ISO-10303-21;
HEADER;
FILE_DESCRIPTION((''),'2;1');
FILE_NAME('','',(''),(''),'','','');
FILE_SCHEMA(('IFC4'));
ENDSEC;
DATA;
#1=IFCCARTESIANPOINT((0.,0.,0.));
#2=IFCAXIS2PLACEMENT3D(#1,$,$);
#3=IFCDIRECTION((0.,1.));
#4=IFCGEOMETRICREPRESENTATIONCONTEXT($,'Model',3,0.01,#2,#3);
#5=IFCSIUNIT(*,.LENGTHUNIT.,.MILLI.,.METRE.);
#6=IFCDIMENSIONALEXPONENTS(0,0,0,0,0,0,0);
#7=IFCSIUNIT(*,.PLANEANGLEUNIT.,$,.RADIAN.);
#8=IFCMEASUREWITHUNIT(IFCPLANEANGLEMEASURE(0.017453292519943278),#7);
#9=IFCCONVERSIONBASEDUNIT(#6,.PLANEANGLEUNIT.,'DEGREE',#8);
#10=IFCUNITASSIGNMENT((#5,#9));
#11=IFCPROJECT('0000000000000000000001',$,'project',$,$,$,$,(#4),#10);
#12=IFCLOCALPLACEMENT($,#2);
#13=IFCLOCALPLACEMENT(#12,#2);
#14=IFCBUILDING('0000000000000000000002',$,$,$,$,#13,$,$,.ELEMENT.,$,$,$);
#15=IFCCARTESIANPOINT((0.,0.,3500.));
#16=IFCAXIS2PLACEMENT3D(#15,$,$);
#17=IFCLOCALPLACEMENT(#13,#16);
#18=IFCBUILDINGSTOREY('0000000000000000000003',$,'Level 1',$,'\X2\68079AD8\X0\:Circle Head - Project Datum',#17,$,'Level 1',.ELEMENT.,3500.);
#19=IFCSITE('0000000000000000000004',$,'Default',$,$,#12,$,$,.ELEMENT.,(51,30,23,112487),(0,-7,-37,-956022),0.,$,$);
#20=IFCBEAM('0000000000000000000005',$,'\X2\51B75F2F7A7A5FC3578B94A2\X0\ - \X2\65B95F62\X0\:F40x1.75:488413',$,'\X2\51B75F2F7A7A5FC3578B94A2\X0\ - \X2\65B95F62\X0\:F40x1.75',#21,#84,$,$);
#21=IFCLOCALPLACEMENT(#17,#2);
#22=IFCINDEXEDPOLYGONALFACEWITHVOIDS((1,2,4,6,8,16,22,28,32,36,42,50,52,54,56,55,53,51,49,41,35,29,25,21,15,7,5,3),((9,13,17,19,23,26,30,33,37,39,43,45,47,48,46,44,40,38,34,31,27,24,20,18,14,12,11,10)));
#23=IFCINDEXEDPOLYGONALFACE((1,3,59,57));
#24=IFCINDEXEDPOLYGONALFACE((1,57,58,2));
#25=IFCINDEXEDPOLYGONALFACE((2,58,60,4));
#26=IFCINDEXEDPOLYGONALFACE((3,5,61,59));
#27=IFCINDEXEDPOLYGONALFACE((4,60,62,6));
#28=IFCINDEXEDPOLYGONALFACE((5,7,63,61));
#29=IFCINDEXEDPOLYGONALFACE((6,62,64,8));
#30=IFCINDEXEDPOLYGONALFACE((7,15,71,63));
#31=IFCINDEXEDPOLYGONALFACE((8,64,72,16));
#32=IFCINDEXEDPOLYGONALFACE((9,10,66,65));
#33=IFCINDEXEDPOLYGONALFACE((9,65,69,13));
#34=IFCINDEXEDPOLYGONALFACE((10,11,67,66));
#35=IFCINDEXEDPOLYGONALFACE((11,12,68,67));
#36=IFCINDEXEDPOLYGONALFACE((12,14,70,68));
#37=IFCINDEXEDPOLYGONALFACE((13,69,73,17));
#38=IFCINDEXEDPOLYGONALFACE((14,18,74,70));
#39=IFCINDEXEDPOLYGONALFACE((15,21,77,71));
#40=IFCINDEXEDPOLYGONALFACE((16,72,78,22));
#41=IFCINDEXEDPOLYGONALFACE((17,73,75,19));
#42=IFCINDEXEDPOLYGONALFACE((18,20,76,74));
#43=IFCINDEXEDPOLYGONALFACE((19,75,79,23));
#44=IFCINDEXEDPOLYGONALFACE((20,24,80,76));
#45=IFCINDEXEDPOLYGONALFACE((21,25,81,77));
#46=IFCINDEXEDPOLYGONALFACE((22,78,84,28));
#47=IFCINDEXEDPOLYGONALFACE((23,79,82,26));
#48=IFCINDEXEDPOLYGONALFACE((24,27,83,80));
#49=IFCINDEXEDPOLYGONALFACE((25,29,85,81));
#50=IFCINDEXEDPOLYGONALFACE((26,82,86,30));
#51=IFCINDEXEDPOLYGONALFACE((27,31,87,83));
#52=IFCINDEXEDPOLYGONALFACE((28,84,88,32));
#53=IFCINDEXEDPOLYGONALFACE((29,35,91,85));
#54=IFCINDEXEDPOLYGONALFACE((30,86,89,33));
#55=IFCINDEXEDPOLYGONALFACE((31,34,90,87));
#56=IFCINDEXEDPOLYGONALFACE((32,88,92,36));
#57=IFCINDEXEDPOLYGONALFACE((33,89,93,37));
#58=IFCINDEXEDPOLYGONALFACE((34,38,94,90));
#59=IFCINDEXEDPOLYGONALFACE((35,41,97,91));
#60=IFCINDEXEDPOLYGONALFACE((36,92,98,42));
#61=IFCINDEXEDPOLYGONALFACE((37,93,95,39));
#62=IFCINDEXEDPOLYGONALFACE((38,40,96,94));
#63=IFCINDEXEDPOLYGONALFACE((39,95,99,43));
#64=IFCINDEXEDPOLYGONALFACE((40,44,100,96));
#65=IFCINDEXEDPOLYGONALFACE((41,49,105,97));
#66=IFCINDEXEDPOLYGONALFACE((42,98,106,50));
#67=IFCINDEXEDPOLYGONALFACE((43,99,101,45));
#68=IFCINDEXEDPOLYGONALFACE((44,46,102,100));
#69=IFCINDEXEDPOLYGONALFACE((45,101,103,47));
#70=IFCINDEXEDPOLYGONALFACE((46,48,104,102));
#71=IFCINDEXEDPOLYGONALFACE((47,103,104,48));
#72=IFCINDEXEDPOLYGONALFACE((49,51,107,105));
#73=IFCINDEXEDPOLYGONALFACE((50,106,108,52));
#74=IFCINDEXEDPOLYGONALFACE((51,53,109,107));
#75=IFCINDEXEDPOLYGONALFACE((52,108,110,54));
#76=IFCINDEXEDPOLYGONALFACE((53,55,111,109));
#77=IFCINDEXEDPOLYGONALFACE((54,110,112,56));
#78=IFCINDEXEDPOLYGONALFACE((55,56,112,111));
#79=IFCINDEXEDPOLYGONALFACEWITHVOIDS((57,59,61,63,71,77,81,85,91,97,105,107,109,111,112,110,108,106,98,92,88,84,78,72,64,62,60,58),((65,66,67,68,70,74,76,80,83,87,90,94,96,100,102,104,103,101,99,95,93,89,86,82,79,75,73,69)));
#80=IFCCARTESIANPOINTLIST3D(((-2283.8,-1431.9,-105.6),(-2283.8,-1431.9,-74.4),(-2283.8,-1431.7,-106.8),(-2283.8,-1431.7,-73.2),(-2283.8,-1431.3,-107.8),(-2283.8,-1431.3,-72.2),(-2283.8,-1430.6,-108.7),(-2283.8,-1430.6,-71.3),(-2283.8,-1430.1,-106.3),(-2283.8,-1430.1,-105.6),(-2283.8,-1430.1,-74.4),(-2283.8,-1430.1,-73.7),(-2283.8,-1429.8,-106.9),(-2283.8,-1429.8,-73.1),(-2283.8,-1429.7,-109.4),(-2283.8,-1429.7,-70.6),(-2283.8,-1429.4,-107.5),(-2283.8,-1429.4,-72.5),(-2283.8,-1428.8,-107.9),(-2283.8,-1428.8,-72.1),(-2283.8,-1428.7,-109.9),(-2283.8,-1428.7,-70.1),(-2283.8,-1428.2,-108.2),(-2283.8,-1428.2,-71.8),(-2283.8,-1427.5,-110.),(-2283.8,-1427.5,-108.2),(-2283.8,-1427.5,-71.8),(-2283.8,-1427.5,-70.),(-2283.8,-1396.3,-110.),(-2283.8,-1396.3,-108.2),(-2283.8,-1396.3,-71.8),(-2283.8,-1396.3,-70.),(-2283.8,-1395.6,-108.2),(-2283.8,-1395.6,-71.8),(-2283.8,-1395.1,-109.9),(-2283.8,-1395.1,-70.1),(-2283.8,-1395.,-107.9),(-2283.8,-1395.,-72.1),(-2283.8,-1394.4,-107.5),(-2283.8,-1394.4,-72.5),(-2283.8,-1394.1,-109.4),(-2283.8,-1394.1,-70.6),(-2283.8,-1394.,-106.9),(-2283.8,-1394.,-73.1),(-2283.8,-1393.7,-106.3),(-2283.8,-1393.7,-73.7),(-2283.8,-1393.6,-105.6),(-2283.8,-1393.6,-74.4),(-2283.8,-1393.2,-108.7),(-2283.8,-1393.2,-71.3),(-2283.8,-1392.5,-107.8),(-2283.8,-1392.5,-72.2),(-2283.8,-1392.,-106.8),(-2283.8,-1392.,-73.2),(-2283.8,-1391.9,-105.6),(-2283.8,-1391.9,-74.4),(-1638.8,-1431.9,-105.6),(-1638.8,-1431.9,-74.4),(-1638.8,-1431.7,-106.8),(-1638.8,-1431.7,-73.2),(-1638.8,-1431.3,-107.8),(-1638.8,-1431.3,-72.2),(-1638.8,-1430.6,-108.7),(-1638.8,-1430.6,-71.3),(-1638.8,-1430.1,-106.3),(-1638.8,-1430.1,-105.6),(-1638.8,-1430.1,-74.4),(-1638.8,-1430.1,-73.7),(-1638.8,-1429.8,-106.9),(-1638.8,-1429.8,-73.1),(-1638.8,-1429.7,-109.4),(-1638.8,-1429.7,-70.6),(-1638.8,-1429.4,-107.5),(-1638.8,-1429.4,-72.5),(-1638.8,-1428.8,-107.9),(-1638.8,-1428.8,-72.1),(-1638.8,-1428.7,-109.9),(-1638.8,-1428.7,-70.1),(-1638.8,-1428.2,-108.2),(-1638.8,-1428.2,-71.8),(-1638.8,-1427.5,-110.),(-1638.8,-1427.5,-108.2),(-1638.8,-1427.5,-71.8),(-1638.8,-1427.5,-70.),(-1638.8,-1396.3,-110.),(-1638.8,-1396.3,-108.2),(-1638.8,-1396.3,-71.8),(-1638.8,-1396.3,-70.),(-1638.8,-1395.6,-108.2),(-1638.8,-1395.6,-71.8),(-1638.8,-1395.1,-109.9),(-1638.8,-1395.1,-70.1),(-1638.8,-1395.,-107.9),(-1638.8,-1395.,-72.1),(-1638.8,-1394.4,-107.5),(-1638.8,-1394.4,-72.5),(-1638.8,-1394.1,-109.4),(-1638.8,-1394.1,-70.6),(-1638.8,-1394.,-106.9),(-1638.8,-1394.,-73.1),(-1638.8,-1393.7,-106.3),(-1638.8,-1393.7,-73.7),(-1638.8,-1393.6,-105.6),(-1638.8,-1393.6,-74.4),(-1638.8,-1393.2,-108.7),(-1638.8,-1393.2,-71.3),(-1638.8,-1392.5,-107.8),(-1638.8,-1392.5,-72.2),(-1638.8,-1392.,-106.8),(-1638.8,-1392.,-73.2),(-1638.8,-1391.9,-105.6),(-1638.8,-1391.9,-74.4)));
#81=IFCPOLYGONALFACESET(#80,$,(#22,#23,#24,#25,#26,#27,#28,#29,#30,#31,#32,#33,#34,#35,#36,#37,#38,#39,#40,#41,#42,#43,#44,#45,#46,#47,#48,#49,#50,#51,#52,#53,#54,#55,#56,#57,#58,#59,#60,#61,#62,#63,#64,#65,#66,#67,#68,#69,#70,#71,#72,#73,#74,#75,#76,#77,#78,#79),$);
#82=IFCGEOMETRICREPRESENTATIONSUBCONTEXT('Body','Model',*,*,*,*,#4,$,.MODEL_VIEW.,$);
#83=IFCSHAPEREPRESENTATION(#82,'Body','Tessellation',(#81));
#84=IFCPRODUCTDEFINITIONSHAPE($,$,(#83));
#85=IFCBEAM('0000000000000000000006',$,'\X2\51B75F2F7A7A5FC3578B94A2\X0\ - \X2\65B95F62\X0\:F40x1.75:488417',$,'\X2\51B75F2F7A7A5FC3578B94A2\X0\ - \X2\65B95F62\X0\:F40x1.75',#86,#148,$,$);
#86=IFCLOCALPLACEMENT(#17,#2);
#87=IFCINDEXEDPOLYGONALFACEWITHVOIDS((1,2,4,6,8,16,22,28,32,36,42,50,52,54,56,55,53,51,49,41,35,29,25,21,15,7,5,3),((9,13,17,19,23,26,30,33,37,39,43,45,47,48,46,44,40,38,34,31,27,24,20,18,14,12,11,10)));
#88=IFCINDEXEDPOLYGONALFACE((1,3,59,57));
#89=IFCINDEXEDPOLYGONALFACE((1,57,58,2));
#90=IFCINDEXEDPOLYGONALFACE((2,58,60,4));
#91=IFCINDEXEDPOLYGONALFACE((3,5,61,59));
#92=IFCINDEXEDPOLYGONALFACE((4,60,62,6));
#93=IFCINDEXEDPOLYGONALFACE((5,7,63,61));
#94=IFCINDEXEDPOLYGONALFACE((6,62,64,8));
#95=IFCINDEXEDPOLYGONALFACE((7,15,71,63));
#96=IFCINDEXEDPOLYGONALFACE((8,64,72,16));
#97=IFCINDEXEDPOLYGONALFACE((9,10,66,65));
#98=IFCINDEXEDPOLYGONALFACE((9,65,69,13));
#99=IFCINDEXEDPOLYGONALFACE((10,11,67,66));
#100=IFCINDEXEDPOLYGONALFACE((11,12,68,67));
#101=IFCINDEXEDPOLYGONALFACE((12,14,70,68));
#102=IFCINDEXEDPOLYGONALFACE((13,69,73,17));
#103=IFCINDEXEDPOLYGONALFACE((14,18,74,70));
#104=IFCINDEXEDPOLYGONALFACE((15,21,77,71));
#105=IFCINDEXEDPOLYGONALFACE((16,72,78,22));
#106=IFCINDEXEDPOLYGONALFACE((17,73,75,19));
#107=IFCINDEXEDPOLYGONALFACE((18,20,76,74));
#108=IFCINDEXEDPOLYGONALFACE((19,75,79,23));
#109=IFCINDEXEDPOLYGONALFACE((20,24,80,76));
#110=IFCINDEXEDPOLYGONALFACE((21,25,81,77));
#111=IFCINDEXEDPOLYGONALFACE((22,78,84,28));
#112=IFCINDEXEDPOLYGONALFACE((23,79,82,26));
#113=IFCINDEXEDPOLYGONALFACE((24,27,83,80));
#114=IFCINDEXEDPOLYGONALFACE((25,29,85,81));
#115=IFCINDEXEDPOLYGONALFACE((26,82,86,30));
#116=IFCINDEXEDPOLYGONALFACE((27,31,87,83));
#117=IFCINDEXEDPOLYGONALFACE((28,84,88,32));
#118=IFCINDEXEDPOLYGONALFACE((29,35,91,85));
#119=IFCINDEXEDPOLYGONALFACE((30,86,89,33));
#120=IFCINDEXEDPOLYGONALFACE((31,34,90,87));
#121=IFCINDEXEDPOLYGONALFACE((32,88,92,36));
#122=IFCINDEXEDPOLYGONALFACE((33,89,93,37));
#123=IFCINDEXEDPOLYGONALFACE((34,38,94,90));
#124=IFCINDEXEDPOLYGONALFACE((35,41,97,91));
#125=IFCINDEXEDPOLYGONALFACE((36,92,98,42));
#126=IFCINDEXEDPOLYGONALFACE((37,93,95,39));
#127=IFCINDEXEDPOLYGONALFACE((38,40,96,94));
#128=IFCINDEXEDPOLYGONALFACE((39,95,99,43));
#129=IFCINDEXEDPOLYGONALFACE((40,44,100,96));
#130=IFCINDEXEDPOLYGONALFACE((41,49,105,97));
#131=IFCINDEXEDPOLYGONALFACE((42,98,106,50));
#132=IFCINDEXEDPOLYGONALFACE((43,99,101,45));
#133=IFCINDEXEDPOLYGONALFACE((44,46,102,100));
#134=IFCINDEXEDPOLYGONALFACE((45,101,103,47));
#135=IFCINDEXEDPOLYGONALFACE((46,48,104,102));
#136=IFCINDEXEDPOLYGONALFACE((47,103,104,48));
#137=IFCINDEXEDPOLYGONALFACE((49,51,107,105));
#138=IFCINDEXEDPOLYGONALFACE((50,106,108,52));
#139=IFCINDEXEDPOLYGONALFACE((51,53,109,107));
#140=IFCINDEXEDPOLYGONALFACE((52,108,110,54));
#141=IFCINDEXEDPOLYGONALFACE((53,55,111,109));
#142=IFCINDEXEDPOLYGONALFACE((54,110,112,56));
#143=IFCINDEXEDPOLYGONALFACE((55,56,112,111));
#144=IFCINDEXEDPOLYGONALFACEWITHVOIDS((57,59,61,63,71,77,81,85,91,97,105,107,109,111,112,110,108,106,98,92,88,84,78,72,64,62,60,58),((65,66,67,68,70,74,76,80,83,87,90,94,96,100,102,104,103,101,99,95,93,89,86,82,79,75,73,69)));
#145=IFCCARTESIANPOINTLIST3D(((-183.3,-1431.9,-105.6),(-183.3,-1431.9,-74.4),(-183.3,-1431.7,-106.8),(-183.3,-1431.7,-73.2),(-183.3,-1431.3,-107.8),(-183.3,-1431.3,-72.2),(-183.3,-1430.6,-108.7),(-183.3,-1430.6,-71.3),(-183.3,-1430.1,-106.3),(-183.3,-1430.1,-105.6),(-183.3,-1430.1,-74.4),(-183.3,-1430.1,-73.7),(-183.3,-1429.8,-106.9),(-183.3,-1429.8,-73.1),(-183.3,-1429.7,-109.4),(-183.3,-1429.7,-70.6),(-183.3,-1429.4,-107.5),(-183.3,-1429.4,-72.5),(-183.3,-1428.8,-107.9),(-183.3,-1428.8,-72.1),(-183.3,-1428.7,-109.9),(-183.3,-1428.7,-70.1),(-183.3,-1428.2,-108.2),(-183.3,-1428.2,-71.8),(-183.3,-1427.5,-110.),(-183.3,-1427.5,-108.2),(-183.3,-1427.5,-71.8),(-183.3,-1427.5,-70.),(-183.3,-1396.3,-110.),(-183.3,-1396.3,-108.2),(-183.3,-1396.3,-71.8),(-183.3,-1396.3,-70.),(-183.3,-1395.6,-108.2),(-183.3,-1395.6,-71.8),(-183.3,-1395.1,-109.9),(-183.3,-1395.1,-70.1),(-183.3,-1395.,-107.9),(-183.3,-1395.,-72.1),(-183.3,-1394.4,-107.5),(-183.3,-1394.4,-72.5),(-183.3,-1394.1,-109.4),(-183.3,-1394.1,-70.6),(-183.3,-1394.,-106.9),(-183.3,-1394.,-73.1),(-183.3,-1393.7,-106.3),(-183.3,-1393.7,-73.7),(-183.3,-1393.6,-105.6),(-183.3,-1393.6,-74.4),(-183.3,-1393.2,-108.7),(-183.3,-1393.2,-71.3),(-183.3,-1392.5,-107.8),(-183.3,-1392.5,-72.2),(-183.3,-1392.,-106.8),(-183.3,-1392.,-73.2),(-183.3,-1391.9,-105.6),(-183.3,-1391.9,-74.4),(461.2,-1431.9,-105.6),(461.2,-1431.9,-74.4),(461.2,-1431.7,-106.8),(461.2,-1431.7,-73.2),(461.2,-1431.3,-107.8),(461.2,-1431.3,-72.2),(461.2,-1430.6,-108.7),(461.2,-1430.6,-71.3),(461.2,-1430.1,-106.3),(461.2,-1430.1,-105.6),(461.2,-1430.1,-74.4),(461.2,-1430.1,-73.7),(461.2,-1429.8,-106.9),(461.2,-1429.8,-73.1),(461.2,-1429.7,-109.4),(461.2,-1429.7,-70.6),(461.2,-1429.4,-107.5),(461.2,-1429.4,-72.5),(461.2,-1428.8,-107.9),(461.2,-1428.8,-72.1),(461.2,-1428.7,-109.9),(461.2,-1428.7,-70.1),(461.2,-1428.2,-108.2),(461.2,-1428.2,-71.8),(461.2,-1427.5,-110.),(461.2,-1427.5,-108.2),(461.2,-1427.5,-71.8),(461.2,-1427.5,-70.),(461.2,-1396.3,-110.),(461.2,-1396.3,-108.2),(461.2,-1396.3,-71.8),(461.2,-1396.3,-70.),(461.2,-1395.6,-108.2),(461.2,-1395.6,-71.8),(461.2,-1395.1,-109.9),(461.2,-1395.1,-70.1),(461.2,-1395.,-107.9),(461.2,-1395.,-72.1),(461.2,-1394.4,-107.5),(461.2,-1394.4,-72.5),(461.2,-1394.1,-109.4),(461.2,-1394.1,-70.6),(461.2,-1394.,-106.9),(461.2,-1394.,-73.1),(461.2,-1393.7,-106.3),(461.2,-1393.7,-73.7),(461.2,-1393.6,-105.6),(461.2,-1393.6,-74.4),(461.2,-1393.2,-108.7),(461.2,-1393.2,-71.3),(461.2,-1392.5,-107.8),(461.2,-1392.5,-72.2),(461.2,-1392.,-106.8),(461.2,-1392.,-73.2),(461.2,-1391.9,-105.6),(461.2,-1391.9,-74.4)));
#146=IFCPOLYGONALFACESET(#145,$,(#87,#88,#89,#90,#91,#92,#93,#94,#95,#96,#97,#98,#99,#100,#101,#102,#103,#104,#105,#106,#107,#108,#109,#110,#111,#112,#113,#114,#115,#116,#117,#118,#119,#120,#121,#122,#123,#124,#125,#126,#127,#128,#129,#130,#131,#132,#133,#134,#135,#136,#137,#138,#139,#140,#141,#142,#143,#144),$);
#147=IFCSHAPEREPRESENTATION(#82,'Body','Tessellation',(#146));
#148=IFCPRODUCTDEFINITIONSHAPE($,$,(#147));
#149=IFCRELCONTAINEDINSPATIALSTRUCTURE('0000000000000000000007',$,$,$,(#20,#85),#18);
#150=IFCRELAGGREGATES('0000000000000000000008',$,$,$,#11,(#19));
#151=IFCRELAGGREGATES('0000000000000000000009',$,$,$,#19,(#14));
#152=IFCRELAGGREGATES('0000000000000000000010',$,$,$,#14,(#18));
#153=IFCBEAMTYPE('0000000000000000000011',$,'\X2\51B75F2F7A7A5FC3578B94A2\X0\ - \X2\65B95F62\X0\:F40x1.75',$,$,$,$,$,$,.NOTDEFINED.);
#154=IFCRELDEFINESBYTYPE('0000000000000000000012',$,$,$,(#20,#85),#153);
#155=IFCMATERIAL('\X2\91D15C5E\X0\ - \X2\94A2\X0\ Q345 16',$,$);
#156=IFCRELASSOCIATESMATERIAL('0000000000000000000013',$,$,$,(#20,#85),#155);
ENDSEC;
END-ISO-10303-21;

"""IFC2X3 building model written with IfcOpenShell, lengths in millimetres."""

from ifc_helpers import new_model, entity, si_unit, converted_unit, direction, frame, frame_2d, origin, place, context, subcontext, project, spatial, polyline, circle_curve, parameter, trimmed, segment, composite_curve, outline, extrude, material, type_object, element, save


model = new_model("IFC2X3")

# Units and contexts
model_context = context("Model", 3, precision=0.01, world=origin(), true_north=direction((0.0, 1.0)))
body_context = subcontext(model_context, "Body", "Model", "MODEL_VIEW")
ifc_project = project(units=[si_unit("LENGTHUNIT", "METRE", prefix="MILLI"), converted_unit("PLANEANGLEUNIT", "DEGREE", entity("IfcPlaneAngleMeasure", 0.017453292519943278), si_unit("PLANEANGLEUNIT", "RADIAN"), dimensions=[0, 0, 0, 0, 0, 0, 0])], contexts=[model_context])

# Site, building, storey
site_placement = place(None, origin())
site = spatial("IfcSite", under=ifc_project, at=site_placement, Name="Default", CompositionType="ELEMENT", RefLatitude=(51, 30, 23, 112487), RefLongitude=(0, -7, -37, -956022), RefElevation=0.0)
building_placement = place(site_placement, origin())
building = spatial("IfcBuilding", under=site, at=building_placement, CompositionType="ELEMENT")
storey_placement = place(building_placement, frame((0.0, 0.0, 3500.0)))
storey = spatial("IfcBuildingStorey", under=building, at=storey_placement, Name="Level 1", ObjectType="标高:Circle Head - Project Datum", LongName="Level 1", CompositionType="ELEMENT", Elevation=3500.0)

# Beams
ifc_material_1 = material(Name="金属 - 钢 Q345 16")
beam_type_1 = type_object("IfcBeamType", Name="冷弯空心型钢 - 方形:F40x1.75", PredefinedType="NOTDEFINED")
beam_1_placement = place(storey_placement, frame((-2311.3, -1411.9, -70.0)))
element("IfcBeam", 1, at=beam_1_placement, inside=storey, type_object=beam_type_1, material=ifc_material_1, Name="冷弯空心型钢 - 方形:F40x1.75:488413", ObjectType="冷弯空心型钢 - 方形:F40x1.75", context=body_context, shape_type="SweptSolid", body=[
    extrude(outline(composite_curve([segment(trimmed(circle_curve(frame_2d((-15.6, 15.6), x_axis=(1.0, 0.0)), 4.4), [parameter(90.0)], [parameter(180.0)], True, "PARAMETER"), True, "CONTINUOUS"), segment(polyline([(-20.0, 15.6), (-20.0, -15.6)]), True, "CONTINUOUS"), segment(trimmed(circle_curve(frame_2d((-15.6, -15.6), x_axis=(1.0, 0.0)), 4.4), [parameter(180.0)], [parameter(270.0)], True, "PARAMETER"), True, "CONTINUOUS"), segment(polyline([(-15.6, -20.0), (15.6, -20.0)]), True, "CONTINUOUS"), segment(trimmed(circle_curve(frame_2d((15.6, -15.6), x_axis=(1.0, 0.0)), 4.4), [parameter(270.0)], [parameter(0.0)], True, "PARAMETER"), True, "CONTINUOUS"), segment(polyline([(20.0, -15.6), (20.0, 15.6)]), True, "CONTINUOUS"), segment(trimmed(circle_curve(frame_2d((15.6, 15.6), x_axis=(1.0, 0.0)), 4.4), [parameter(0.0)], [parameter(90.0)], True, "PARAMETER"), True, "CONTINUOUS"), segment(polyline([(15.6, 20.0), (-15.6, 20.0)]), True, "CONTINUOUS")], self_intersect=False), holes=[composite_curve([segment(polyline([(-15.6, 18.3), (15.6, 18.3)]), True, "CONTINUOUS"), segment(trimmed(circle_curve(frame_2d((15.6, 15.6), x_axis=(1.0, 0.0)), 2.6), [parameter(0.0)], [parameter(90.0)], True, "PARAMETER"), False, "CONTINUOUS"), segment(polyline([(18.2, 15.6), (18.2, -15.6)]), True, "CONTINUOUS"), segment(trimmed(circle_curve(frame_2d((15.6, -15.6), x_axis=(1.0, 0.0)), 2.6), [parameter(270.0)], [parameter(360.0)], True, "PARAMETER"), False, "CONTINUOUS"), segment(polyline([(15.6, -18.3), (-15.6, -18.3)]), True, "CONTINUOUS"), segment(trimmed(circle_curve(frame_2d((-15.6, -15.6), x_axis=(1.0, 0.0)), 2.6), [parameter(180.0)], [parameter(270.0)], True, "PARAMETER"), False, "CONTINUOUS"), segment(polyline([(-18.3, -15.6), (-18.3, 15.6)]), True, "CONTINUOUS"), segment(trimmed(circle_curve(frame_2d((-15.6, 15.6), x_axis=(1.0, 0.0)), 2.6), [parameter(90.0)], [parameter(180.0)], True, "PARAMETER"), False, "CONTINUOUS")], self_intersect=False)]), frame((27.5, 0.0, -20.0), z_axis=(1.0, 0.0, 0.0), x_axis=(0.0, 1.0, 0.0)), (0.0, 0.0, 1.0), 645.0),
])
beam_2_placement = place(storey_placement, frame((-231.3, -1411.9, -70.0)))
element("IfcBeam", 2, at=beam_2_placement, inside=storey, type_object=beam_type_1, material=ifc_material_1, Name="冷弯空心型钢 - 方形:F40x1.75:488417", ObjectType="冷弯空心型钢 - 方形:F40x1.75", context=body_context, shape_type="SweptSolid", body=[
    extrude(outline(composite_curve([segment(trimmed(circle_curve(frame_2d((-15.6, 15.6), x_axis=(1.0, 0.0)), 4.4), [parameter(90.0)], [parameter(180.0)], True, "PARAMETER"), True, "CONTINUOUS"), segment(polyline([(-20.0, 15.6), (-20.0, -15.6)]), True, "CONTINUOUS"), segment(trimmed(circle_curve(frame_2d((-15.6, -15.6), x_axis=(1.0, 0.0)), 4.4), [parameter(180.0)], [parameter(270.0)], True, "PARAMETER"), True, "CONTINUOUS"), segment(polyline([(-15.6, -20.0), (15.6, -20.0)]), True, "CONTINUOUS"), segment(trimmed(circle_curve(frame_2d((15.6, -15.6), x_axis=(1.0, 0.0)), 4.4), [parameter(270.0)], [parameter(0.0)], True, "PARAMETER"), True, "CONTINUOUS"), segment(polyline([(20.0, -15.6), (20.0, 15.6)]), True, "CONTINUOUS"), segment(trimmed(circle_curve(frame_2d((15.6, 15.6), x_axis=(1.0, 0.0)), 4.4), [parameter(0.0)], [parameter(90.0)], True, "PARAMETER"), True, "CONTINUOUS"), segment(polyline([(15.6, 20.0), (-15.6, 20.0)]), True, "CONTINUOUS")], self_intersect=False), holes=[composite_curve([segment(polyline([(-15.6, 18.3), (15.6, 18.3)]), True, "CONTINUOUS"), segment(trimmed(circle_curve(frame_2d((15.6, 15.6), x_axis=(1.0, 0.0)), 2.6), [parameter(0.0)], [parameter(90.0)], True, "PARAMETER"), False, "CONTINUOUS"), segment(polyline([(18.2, 15.6), (18.2, -15.6)]), True, "CONTINUOUS"), segment(trimmed(circle_curve(frame_2d((15.6, -15.6), x_axis=(1.0, 0.0)), 2.6), [parameter(270.0)], [parameter(360.0)], True, "PARAMETER"), False, "CONTINUOUS"), segment(polyline([(15.6, -18.3), (-15.6, -18.3)]), True, "CONTINUOUS"), segment(trimmed(circle_curve(frame_2d((-15.6, -15.6), x_axis=(1.0, 0.0)), 2.6), [parameter(180.0)], [parameter(270.0)], True, "PARAMETER"), False, "CONTINUOUS"), segment(polyline([(-18.3, -15.6), (-18.3, 15.6)]), True, "CONTINUOUS"), segment(trimmed(circle_curve(frame_2d((-15.6, 15.6), x_axis=(1.0, 0.0)), 2.6), [parameter(90.0)], [parameter(180.0)], True, "PARAMETER"), False, "CONTINUOUS")], self_intersect=False)]), frame((48.0, 0.0, -20.0), z_axis=(1.0, 0.0, 0.0), x_axis=(0.0, 1.0, 0.0)), (0.0, 0.0, 1.0), 644.5),
])

save(model, "model.ifc")
